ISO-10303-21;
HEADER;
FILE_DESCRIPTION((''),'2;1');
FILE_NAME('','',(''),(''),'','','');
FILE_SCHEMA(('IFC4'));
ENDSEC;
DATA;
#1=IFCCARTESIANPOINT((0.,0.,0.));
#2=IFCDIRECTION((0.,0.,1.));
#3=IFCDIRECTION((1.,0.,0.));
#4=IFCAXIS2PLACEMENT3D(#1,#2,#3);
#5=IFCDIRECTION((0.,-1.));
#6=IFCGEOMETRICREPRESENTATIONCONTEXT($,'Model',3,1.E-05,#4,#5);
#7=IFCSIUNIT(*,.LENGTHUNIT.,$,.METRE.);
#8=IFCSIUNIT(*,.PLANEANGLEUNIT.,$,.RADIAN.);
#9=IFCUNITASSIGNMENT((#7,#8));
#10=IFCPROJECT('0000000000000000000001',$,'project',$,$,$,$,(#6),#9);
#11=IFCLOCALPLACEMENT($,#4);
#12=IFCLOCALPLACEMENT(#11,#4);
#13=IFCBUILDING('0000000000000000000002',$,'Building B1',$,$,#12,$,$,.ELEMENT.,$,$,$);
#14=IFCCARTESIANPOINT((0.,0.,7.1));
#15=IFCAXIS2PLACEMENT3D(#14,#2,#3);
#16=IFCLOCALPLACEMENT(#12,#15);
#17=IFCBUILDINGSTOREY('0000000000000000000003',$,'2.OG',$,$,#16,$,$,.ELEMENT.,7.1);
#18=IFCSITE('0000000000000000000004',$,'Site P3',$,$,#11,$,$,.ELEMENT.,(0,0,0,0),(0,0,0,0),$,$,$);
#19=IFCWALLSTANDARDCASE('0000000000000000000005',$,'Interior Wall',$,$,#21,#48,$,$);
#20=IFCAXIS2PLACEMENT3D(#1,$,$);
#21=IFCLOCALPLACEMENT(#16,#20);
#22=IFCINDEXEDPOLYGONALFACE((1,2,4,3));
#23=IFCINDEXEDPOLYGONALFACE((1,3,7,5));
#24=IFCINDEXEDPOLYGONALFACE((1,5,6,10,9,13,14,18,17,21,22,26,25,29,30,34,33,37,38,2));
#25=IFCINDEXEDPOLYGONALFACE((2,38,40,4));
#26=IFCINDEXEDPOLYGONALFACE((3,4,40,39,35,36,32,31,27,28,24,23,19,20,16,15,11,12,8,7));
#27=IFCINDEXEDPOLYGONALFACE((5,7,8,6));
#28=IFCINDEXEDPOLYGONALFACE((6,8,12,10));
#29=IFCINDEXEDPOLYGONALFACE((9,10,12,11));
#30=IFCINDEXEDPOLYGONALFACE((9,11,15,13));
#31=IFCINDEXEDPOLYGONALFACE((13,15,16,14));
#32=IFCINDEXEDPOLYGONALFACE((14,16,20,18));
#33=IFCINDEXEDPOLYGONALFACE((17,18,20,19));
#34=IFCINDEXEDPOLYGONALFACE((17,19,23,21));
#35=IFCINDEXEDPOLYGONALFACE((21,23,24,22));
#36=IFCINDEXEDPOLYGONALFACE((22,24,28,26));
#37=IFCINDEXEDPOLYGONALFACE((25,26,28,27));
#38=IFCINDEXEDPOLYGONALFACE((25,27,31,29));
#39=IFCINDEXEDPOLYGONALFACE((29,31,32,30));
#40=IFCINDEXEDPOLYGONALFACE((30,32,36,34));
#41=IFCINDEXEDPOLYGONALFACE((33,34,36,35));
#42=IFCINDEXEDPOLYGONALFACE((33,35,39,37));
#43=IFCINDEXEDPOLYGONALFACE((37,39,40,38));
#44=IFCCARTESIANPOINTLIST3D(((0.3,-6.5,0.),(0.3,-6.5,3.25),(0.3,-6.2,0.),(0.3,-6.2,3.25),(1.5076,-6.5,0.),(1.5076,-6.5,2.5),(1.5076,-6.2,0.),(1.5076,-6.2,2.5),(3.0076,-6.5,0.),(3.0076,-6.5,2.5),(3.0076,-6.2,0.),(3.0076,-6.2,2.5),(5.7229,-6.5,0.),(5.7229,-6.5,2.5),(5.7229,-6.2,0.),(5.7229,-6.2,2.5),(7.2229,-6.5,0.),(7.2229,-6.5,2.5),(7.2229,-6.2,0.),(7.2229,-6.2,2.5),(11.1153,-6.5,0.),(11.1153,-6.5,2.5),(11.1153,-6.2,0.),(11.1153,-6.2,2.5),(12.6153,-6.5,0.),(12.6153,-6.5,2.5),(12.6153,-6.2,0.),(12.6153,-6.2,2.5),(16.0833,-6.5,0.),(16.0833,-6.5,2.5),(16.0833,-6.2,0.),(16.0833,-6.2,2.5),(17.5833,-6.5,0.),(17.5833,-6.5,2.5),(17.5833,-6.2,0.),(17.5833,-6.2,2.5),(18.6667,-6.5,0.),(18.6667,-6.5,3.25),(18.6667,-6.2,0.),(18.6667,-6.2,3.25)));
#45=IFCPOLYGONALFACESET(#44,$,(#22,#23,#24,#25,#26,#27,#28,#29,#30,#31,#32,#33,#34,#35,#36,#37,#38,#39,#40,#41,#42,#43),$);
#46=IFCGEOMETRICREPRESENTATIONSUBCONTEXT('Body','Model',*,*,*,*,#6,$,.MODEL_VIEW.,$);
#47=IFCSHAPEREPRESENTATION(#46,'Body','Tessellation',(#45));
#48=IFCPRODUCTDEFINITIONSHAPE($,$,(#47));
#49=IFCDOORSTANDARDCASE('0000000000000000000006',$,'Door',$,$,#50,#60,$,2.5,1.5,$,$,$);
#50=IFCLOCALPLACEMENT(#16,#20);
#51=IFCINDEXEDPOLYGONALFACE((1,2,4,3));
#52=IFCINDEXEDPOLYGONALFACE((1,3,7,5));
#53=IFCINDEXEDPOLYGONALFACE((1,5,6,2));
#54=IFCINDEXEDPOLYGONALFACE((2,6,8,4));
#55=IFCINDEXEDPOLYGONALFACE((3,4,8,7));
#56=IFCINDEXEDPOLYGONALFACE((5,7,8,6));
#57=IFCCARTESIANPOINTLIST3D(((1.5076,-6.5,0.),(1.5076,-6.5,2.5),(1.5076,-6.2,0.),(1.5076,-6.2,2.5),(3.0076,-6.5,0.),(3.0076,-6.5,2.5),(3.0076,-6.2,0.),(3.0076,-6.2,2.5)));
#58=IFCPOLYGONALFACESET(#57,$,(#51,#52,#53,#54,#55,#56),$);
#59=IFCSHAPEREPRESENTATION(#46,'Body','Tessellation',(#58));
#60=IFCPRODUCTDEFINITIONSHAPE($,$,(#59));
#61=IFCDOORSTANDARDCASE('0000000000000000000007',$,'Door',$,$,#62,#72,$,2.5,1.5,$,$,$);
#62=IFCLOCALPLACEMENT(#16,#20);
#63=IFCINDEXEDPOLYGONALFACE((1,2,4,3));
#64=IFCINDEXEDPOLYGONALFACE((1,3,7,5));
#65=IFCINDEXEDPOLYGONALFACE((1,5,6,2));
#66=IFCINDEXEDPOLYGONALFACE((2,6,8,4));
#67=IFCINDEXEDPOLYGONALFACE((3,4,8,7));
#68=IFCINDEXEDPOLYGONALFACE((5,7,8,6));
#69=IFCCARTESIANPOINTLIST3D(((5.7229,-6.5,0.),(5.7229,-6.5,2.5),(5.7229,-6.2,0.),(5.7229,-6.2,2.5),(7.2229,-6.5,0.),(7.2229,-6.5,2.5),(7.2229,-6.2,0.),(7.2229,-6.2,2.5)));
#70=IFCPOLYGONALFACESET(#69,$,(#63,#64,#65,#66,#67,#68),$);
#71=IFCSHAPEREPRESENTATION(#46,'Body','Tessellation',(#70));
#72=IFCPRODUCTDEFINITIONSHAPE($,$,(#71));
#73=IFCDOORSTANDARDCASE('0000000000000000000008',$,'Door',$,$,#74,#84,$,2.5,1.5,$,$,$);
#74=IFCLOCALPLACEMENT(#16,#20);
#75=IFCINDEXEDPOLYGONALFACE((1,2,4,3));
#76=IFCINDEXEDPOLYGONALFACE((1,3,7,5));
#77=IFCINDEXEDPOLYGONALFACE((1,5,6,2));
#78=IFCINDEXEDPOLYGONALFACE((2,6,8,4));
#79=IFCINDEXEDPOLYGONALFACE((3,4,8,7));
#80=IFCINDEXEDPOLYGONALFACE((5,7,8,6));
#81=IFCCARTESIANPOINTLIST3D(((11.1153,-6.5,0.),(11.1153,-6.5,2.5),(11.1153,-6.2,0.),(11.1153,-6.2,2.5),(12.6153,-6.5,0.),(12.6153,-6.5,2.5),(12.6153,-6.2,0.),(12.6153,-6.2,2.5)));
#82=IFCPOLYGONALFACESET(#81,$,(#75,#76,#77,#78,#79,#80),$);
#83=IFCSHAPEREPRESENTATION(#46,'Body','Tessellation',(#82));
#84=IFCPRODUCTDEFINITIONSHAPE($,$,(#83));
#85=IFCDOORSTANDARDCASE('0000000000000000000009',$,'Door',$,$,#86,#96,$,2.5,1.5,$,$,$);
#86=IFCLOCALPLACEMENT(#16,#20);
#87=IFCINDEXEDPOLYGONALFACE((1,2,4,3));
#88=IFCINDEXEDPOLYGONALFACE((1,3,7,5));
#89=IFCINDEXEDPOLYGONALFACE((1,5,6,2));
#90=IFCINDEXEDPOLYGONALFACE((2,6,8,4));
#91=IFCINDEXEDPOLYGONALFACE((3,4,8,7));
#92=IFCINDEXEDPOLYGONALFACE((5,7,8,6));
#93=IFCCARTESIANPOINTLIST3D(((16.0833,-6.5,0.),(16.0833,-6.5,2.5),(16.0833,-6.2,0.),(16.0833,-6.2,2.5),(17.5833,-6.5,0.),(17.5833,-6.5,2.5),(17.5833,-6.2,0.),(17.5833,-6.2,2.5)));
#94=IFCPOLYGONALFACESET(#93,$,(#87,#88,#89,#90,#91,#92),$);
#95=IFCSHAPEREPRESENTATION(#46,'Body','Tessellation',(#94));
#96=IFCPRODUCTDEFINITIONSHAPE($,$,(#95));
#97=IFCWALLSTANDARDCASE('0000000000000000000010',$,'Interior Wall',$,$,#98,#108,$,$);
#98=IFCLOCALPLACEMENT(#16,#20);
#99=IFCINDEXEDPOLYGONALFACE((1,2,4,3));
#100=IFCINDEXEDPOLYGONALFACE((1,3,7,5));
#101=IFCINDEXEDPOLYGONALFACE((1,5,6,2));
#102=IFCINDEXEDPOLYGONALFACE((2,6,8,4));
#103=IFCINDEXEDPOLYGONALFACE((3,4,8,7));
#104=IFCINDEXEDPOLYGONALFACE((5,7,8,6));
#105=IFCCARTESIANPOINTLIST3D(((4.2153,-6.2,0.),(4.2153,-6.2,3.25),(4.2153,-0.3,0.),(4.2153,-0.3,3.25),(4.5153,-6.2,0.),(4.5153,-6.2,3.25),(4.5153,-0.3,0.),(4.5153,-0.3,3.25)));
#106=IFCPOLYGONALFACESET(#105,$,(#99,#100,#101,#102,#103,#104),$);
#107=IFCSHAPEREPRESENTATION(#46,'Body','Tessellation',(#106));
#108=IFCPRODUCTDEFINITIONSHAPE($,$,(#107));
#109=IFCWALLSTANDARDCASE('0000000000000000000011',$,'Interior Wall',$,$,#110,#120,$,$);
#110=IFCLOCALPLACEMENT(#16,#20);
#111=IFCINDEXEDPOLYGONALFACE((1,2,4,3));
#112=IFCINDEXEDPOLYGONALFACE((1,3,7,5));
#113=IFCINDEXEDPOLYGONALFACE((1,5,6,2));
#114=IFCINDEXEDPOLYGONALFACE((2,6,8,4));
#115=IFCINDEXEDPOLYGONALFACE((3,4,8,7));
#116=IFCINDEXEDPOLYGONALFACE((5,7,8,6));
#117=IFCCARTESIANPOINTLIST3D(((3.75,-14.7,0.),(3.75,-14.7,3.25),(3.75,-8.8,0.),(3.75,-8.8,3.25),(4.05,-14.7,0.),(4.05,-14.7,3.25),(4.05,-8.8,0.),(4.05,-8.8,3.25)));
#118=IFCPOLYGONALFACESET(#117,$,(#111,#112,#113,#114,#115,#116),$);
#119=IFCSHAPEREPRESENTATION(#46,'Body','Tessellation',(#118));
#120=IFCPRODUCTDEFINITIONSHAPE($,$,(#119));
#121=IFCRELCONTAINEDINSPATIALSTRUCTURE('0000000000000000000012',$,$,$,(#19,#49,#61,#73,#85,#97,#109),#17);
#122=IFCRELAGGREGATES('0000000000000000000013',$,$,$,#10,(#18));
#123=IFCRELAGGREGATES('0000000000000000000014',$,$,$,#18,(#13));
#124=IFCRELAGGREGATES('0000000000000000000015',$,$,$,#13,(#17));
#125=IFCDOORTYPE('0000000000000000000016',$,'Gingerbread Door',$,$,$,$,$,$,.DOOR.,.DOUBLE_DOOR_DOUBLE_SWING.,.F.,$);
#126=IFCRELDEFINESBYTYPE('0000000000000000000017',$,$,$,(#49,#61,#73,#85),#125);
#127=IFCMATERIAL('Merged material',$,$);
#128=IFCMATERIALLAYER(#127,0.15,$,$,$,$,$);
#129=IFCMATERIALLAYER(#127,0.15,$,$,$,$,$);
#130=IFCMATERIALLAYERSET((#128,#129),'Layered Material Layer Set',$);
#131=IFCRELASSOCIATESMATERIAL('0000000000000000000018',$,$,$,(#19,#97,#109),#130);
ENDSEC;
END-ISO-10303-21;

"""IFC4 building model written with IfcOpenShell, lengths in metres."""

from ifc_helpers import new_model, si_unit, direction, frame, origin_with_axes, place, context, subcontext, project, spatial, polyline, outline, extrude, source, transform, mapped, material, layer, layer_set, layer_usage, type_object, element, fill, save


model = new_model("IFC4")

# Units and contexts
model_context = context("Model", 3, precision=1e-05, world=origin_with_axes(), true_north=direction((0.0, -1.0)))
body_context = subcontext(model_context, "Body", "Model", "MODEL_VIEW")
ifc_project = project(units=[si_unit("LENGTHUNIT", "METRE"), si_unit("PLANEANGLEUNIT", "RADIAN")], contexts=[model_context])

# Site, building, storey
site_placement = place(None, origin_with_axes())
site = spatial("IfcSite", under=ifc_project, at=site_placement, Name="Site P3", CompositionType="ELEMENT", RefLatitude=(0, 0, 0, 0), RefLongitude=(0, 0, 0, 0))
building_placement = place(site_placement, origin_with_axes())
building = spatial("IfcBuilding", under=site, at=building_placement, Name="Building B1", CompositionType="ELEMENT")
storey_placement = place(building_placement, frame((0.0, 0.0, 7.1), z_axis=(0.0, 0.0, 1.0), x_axis=(1.0, 0.0, 0.0)))
storey = spatial("IfcBuildingStorey", under=building, at=storey_placement, Name="2.OG", CompositionType="ELEMENT", Elevation=7.1)

# Shared definitions
ifc_material = material(Name="Merged material")

# Wall, openings, doors
ifc_layer_1 = layer(ifc_material, 0.15)
ifc_layer_2 = layer(ifc_material, 0.15)
ifc_layer_set_1 = layer_set([ifc_layer_1, ifc_layer_2], Name="Layered Material Layer Set")
ifc_layer_usage_1 = layer_usage(ifc_layer_set_1, "AXIS2", "POSITIVE", -0.15)
door_type = type_object("IfcDoorType", Name="Gingerbread Door", OperationType="DOUBLE_DOOR_DOUBLE_SWING", ParameterTakesPrecedence=False, PredefinedType="DOOR")
shared_shape_1 = source(origin_with_axes(), body_context, "Body", "SweptSolid", [
    extrude(outline(polyline([(0.0, 0.0), (0.0, 1.5), (2.5, 1.5), (2.5, 0.0), (0.0, 0.0)])), frame((0.0, -0.15, 0.0), z_axis=(0.0, 1.0, 0.0), x_axis=(0.0, 0.0, 1.0)), (0.0, 0.0, 1.0), 0.3),
])
wall_1_placement = place(storey_placement, frame((0.3, -6.35, 0.0), z_axis=(0.0, 0.0, 1.0), x_axis=(1.0, 0.0, 0.0)))
wall_1 = element("IfcWallStandardCase", 1, at=wall_1_placement, inside=storey, material=ifc_layer_usage_1, Name="Interior Wall", context=body_context, shape_type="SweptSolid", body=[
    extrude(outline(polyline([(0.0, 0.15), (18.3667, 0.15), (18.3667, -0.15), (0.0, -0.15), (0.0, 0.15)])), origin_with_axes(), (0.0, 0.0, 1.0), 3.25),
])
opening_1_placement = place(wall_1_placement, frame((1.2076, 0.0, 0.0), z_axis=(0.0, 0.0, 1.0), x_axis=(1.0, 0.0, 0.0)))
opening_1 = element("IfcOpeningStandardCase", 2, at=opening_1_placement, cuts=wall_1, context=body_context, shape_type="SweptSolid", body=[
    extrude(outline(polyline([(0.0, 0.0), (0.0, 1.5), (2.5, 1.5), (2.5, 0.0), (0.0, 0.0)])), frame((0.0, -0.15, 0.0), z_axis=(0.0, 1.0, 0.0), x_axis=(0.0, 0.0, 1.0)), (0.0, 0.0, 1.0), 0.3),
])
opening_2_placement = place(wall_1_placement, frame((5.4229, 0.0, 0.0), z_axis=(0.0, 0.0, 1.0), x_axis=(1.0, 0.0, 0.0)))
opening_2 = element("IfcOpeningStandardCase", 3, at=opening_2_placement, cuts=wall_1, context=body_context, shape_type="SweptSolid", body=[
    extrude(outline(polyline([(0.0, 0.0), (0.0, 1.5), (2.5, 1.5), (2.5, 0.0), (0.0, 0.0)])), frame((0.0, -0.15, 0.0), z_axis=(0.0, 1.0, 0.0), x_axis=(0.0, 0.0, 1.0)), (0.0, 0.0, 1.0), 0.3),
])
opening_3_placement = place(wall_1_placement, frame((10.8153, 0.0, 0.0), z_axis=(0.0, 0.0, 1.0), x_axis=(1.0, 0.0, 0.0)))
opening_3 = element("IfcOpeningStandardCase", 4, at=opening_3_placement, cuts=wall_1, context=body_context, shape_type="SweptSolid", body=[
    extrude(outline(polyline([(0.0, 0.0), (0.0, 1.5), (2.5, 1.5), (2.5, 0.0), (0.0, 0.0)])), frame((0.0, -0.15, 0.0), z_axis=(0.0, 1.0, 0.0), x_axis=(0.0, 0.0, 1.0)), (0.0, 0.0, 1.0), 0.3),
])
opening_4_placement = place(wall_1_placement, frame((15.7833, 0.0, 0.0), z_axis=(0.0, 0.0, 1.0), x_axis=(1.0, 0.0, 0.0)))
opening_4 = element("IfcOpeningStandardCase", 5, at=opening_4_placement, cuts=wall_1, context=body_context, shape_type="SweptSolid", body=[
    extrude(outline(polyline([(0.0, 0.0), (0.0, 1.5), (2.5, 1.5), (2.5, 0.0), (0.0, 0.0)])), frame((0.0, -0.15, 0.0), z_axis=(0.0, 1.0, 0.0), x_axis=(0.0, 0.0, 1.0)), (0.0, 0.0, 1.0), 0.3),
])
door_1_placement = place(opening_1_placement, origin_with_axes())
door_1 = element("IfcDoorStandardCase", 6, at=door_1_placement, inside=storey, type_object=door_type, Name="Door", OverallHeight=2.5, OverallWidth=1.5, context=body_context, shape_type="MappedRepresentation", body=[
    mapped(shared_shape_1, transform((0.0, 0.0, 0.0))),
])
fill(opening_1, door_1)
door_2_placement = place(opening_2_placement, origin_with_axes())
door_2 = element("IfcDoorStandardCase", 7, at=door_2_placement, inside=storey, type_object=door_type, Name="Door", OverallHeight=2.5, OverallWidth=1.5, context=body_context, shape_type="MappedRepresentation", body=[
    mapped(shared_shape_1, transform((0.0, 0.0, 0.0))),
])
fill(opening_2, door_2)
door_3_placement = place(opening_3_placement, origin_with_axes())
door_3 = element("IfcDoorStandardCase", 8, at=door_3_placement, inside=storey, type_object=door_type, Name="Door", OverallHeight=2.5, OverallWidth=1.5, context=body_context, shape_type="MappedRepresentation", body=[
    mapped(shared_shape_1, transform((0.0, 0.0, 0.0))),
])
fill(opening_3, door_3)
door_4_placement = place(opening_4_placement, origin_with_axes())
door_4 = element("IfcDoorStandardCase", 9, at=door_4_placement, inside=storey, type_object=door_type, Name="Door", OverallHeight=2.5, OverallWidth=1.5, context=body_context, shape_type="MappedRepresentation", body=[
    mapped(shared_shape_1, transform((0.0, 0.0, 0.0))),
])
fill(opening_4, door_4)

# Walls
for number, where, z_axis, x_axis, name in (
    (10, (4.3653, -0.3, 0.0), (0.0, 0.0, 1.0), (0.0, -1.0, 0.0), "Interior Wall"),
    (11, (3.9, -8.8, 0.0), (0.0, 0.0, 1.0), (0.0, -1.0, 0.0), "Interior Wall"),
):
    element("IfcWallStandardCase", number, at=place(storey_placement, frame(where, z_axis=z_axis, x_axis=x_axis)), inside=storey, material=ifc_layer_usage_1, Name=name, context=body_context, shape_type="SweptSolid", body=[
        extrude(outline(polyline([(0.0, 0.15), (5.9, 0.15), (5.9, -0.15), (0.0, -0.15), (0.0, 0.15)])), origin_with_axes(), (0.0, 0.0, 1.0), 3.25),
    ])

save(model, "model.ifc")
